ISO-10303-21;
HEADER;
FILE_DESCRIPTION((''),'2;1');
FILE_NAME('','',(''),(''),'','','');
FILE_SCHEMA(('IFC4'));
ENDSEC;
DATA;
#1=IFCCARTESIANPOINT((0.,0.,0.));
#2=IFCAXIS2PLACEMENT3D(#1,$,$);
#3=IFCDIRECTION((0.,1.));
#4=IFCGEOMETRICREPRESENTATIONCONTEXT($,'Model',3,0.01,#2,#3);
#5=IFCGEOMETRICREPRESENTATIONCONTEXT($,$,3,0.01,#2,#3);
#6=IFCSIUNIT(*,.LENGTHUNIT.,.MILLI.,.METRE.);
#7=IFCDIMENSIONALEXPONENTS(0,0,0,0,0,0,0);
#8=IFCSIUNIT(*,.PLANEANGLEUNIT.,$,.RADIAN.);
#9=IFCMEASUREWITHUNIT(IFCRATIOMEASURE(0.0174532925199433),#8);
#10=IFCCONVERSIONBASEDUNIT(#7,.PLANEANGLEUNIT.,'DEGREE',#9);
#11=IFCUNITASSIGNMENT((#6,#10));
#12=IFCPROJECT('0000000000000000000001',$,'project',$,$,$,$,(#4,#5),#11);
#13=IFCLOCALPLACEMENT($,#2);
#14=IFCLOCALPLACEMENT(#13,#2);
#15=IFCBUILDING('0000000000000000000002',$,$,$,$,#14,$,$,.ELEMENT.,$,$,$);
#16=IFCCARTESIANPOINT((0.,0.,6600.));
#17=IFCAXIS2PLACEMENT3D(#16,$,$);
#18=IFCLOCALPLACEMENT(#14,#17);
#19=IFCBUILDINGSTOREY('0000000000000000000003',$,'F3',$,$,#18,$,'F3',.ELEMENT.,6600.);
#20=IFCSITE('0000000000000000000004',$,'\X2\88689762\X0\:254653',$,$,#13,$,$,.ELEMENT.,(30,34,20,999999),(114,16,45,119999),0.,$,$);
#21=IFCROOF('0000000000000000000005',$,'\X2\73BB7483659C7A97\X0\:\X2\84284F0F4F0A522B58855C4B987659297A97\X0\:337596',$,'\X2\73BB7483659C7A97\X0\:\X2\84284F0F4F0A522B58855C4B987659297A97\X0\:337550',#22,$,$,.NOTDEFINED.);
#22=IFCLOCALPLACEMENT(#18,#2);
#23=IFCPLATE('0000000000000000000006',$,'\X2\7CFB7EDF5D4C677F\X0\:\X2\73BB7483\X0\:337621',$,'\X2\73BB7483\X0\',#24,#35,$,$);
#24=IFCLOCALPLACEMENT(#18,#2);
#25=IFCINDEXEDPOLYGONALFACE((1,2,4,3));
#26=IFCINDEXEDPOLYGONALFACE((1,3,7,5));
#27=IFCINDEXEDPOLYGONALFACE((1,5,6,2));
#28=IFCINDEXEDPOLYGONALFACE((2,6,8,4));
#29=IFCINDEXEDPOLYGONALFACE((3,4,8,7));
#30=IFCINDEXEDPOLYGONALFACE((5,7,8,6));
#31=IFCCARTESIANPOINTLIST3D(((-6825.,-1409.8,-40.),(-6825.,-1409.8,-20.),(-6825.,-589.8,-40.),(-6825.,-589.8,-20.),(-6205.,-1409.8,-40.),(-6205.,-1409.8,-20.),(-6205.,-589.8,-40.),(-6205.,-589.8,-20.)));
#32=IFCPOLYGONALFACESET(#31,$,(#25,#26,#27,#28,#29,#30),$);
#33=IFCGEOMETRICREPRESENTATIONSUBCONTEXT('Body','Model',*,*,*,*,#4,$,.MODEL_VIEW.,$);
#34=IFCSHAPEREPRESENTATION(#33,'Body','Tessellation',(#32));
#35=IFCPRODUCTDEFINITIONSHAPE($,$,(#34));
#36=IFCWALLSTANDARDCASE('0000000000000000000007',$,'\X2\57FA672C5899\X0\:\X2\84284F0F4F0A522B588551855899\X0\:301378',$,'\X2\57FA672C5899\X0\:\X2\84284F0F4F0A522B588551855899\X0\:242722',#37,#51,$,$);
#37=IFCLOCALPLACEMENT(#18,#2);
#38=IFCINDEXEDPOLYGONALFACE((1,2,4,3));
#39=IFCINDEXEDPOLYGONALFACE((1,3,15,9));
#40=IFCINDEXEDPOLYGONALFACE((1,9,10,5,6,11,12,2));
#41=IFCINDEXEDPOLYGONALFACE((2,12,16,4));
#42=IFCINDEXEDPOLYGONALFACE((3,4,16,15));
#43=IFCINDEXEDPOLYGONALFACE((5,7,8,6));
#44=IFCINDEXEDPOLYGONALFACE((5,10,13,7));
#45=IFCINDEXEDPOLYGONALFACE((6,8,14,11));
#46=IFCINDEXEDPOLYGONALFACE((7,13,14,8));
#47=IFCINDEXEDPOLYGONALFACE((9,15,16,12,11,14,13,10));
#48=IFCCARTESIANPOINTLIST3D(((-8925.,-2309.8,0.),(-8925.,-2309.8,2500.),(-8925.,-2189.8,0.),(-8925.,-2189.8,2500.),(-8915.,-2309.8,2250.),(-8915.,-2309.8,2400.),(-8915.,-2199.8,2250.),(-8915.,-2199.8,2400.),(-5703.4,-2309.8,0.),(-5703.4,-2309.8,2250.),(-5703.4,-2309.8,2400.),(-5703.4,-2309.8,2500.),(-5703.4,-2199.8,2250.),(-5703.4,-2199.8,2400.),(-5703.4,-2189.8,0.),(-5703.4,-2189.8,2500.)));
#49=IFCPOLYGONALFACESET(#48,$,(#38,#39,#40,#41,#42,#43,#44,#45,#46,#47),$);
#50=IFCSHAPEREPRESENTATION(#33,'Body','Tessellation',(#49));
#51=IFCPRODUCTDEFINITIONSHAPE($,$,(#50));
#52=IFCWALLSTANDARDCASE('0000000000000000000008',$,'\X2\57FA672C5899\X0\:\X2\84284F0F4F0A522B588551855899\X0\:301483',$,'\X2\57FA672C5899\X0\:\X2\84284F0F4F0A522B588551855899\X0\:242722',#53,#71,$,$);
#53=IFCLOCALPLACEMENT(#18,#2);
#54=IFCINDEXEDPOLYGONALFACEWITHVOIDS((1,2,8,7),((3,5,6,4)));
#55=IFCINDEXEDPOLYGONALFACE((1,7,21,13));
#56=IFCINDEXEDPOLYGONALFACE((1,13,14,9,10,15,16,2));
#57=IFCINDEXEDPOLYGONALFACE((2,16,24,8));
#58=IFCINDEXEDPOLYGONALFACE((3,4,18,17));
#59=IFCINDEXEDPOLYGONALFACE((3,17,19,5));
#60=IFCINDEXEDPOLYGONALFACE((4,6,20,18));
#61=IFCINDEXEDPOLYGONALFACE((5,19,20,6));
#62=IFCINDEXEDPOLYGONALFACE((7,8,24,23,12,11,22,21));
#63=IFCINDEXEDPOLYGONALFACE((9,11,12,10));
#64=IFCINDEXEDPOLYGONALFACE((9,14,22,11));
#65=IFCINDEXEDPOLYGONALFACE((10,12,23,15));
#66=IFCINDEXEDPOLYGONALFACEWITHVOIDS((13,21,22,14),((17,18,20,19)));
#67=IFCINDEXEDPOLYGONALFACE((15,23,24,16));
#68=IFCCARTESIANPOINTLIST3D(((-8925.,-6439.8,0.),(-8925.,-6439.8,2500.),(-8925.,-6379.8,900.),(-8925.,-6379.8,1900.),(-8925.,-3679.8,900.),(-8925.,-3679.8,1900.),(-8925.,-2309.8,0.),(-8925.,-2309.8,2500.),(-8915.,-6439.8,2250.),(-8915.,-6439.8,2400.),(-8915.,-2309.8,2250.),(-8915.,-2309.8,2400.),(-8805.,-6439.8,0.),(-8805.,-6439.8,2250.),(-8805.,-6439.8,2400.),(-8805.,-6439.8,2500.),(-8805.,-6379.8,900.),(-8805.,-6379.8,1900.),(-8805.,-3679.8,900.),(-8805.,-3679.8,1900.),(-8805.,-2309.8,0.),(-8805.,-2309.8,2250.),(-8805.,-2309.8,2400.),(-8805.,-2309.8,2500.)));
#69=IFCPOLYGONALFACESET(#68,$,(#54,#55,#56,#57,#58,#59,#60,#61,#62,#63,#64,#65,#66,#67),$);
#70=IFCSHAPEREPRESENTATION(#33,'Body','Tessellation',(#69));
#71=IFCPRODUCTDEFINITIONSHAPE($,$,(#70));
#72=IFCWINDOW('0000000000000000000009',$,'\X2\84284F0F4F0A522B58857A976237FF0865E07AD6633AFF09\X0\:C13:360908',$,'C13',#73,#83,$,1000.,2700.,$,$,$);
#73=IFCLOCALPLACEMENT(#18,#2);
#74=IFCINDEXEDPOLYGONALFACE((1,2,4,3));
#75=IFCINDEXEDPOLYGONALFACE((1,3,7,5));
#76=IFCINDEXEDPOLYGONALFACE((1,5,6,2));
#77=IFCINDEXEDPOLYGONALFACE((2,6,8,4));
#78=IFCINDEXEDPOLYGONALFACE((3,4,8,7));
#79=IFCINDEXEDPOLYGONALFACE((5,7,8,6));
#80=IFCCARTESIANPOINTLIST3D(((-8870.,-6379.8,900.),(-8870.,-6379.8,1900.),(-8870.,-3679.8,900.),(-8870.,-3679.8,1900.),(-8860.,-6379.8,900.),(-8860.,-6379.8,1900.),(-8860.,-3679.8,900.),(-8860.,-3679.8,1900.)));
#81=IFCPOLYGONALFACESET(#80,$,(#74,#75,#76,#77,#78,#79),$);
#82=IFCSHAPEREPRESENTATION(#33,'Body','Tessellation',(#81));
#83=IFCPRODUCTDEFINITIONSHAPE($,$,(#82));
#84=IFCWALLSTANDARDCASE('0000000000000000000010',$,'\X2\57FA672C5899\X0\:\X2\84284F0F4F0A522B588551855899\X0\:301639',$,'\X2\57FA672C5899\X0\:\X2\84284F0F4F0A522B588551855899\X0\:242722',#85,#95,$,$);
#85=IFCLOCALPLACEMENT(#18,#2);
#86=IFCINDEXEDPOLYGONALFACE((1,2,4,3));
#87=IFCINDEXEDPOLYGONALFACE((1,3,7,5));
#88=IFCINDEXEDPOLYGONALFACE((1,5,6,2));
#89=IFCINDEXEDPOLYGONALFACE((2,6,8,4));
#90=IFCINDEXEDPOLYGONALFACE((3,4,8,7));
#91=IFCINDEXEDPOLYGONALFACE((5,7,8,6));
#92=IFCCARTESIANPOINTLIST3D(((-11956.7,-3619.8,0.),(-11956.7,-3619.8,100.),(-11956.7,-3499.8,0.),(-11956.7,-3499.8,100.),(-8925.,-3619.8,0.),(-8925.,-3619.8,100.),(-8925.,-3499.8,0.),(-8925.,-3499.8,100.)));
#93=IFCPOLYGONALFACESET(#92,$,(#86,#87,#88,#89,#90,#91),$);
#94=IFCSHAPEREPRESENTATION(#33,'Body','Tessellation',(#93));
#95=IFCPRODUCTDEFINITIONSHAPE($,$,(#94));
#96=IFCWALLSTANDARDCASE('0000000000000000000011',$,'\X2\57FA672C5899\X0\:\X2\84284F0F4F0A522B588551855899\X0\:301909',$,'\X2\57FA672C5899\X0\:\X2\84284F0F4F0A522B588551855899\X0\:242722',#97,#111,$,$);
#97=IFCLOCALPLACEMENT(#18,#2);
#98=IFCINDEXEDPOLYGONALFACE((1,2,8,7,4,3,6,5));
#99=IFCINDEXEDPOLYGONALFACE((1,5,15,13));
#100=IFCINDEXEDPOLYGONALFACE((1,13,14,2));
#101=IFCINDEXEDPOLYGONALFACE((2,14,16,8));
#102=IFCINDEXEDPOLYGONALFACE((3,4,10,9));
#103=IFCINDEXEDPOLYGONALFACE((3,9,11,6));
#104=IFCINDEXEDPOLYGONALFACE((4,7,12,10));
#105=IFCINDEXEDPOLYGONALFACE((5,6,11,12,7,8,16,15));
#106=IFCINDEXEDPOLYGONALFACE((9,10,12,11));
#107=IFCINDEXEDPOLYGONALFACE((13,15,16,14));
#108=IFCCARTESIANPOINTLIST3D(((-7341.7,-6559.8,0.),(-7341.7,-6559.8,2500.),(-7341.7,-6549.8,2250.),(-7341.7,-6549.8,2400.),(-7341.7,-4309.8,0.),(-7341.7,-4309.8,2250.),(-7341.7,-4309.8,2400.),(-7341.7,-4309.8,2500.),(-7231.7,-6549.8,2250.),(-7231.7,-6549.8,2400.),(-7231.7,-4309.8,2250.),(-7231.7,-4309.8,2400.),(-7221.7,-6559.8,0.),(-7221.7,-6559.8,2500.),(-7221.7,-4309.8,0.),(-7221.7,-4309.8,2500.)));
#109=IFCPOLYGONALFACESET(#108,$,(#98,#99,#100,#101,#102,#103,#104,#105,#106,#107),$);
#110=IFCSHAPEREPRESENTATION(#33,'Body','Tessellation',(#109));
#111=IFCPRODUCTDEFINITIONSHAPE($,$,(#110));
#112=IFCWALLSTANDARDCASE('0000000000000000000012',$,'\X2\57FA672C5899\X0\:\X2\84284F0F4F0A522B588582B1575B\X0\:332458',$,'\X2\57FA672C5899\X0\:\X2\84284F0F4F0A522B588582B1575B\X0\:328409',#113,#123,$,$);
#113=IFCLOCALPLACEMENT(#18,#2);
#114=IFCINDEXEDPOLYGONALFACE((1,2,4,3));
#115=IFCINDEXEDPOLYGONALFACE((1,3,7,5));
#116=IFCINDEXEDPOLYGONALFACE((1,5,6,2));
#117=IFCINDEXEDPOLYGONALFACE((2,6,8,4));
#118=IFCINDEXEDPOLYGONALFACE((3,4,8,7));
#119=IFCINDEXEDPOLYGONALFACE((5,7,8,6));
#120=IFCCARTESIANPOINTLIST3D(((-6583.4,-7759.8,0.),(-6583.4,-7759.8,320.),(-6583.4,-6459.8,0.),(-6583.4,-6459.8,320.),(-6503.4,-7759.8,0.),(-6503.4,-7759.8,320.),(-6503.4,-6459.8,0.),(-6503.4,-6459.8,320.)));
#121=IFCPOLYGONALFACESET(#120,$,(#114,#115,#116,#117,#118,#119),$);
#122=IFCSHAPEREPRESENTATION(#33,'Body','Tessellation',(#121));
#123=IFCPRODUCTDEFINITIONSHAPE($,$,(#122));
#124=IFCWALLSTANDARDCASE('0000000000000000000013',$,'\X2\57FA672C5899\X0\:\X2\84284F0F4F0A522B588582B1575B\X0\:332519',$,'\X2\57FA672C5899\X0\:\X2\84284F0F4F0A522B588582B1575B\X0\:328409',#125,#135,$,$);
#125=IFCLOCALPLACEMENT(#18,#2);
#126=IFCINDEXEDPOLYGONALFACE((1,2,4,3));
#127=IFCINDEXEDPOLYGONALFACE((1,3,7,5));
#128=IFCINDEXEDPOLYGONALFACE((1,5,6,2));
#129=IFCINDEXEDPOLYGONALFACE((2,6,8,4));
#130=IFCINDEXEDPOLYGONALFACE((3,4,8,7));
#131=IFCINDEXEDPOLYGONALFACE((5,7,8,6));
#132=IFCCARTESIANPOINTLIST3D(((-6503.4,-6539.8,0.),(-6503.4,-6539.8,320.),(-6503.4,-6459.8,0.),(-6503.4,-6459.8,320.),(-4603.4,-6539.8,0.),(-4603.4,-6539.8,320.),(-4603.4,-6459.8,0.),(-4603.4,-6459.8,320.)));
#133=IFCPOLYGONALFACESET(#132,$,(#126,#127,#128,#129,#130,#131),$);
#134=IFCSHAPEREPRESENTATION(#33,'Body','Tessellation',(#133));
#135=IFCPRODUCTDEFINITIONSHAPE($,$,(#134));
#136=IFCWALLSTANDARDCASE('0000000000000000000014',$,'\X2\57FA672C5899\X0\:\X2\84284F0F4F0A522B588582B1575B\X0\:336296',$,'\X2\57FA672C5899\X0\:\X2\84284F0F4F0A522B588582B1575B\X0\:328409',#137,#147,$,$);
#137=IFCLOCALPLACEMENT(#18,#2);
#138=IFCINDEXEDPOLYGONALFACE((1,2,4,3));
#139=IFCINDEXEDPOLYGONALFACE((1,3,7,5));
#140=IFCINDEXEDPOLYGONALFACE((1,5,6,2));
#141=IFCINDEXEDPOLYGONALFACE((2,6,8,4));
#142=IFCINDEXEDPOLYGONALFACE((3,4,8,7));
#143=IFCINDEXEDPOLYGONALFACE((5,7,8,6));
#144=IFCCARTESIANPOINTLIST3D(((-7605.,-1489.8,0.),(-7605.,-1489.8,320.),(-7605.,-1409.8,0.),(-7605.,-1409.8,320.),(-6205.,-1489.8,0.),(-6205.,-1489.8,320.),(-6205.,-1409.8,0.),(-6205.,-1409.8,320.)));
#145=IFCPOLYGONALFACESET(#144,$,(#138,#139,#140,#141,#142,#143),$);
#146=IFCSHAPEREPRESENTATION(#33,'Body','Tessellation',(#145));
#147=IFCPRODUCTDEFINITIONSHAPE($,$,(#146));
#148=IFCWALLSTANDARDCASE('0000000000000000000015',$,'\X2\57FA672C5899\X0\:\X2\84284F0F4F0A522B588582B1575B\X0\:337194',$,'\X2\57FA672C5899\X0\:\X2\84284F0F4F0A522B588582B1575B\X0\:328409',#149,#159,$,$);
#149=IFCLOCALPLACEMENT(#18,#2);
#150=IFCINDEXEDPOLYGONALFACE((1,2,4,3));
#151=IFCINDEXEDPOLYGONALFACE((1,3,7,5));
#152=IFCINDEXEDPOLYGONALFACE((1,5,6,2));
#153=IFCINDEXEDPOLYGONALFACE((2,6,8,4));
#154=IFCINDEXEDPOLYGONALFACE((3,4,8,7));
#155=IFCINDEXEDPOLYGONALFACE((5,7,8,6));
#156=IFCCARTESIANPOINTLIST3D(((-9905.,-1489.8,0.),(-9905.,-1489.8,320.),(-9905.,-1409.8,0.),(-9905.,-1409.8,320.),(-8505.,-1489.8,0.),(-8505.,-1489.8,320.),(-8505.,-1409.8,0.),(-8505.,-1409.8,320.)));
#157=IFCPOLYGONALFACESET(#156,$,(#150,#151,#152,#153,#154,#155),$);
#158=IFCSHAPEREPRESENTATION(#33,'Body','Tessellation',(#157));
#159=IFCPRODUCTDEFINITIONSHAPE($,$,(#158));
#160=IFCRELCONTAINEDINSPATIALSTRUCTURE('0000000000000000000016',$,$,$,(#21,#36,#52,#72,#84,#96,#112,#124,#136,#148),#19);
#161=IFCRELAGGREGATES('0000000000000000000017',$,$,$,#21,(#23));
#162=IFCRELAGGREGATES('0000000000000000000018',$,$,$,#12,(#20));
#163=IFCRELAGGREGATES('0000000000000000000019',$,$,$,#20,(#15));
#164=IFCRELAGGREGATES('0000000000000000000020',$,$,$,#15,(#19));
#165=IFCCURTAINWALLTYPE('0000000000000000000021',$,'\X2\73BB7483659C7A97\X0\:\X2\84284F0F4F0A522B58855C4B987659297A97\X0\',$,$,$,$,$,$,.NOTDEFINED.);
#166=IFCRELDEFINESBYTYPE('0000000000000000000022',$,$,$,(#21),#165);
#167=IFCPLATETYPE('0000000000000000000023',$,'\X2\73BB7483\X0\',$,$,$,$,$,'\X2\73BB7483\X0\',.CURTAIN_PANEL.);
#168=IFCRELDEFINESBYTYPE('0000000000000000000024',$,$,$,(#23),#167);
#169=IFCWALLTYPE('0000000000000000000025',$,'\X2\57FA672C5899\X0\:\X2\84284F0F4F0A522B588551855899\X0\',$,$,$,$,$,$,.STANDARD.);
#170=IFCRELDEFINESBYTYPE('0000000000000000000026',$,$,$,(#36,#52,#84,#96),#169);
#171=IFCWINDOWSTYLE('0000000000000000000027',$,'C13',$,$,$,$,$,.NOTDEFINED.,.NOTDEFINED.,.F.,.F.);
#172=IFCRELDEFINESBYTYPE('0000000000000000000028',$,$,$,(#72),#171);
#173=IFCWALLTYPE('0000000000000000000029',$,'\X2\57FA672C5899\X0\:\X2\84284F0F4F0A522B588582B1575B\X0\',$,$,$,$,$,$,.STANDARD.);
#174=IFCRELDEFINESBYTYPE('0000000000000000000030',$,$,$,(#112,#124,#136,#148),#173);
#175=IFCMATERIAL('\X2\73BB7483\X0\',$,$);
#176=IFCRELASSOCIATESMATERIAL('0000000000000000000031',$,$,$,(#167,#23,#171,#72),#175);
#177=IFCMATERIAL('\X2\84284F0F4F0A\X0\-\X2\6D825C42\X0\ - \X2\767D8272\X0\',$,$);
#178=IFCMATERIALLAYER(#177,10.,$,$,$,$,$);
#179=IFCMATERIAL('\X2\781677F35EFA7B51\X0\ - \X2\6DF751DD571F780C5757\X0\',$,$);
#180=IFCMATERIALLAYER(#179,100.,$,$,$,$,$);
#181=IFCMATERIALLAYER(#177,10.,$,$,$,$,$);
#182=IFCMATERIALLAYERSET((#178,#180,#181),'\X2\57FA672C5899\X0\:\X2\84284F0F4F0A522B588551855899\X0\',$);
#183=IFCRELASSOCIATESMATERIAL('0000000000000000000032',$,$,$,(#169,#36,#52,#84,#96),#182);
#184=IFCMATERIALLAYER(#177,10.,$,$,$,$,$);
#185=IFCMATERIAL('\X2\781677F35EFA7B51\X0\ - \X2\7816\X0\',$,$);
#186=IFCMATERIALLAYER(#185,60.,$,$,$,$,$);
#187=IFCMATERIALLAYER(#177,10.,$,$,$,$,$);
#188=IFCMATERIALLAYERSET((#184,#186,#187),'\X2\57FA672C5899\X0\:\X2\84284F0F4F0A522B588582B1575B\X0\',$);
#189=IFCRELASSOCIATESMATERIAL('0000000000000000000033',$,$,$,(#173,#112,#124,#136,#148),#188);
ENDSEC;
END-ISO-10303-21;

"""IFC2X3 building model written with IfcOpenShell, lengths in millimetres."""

from ifc_helpers import new_model, entity, si_unit, converted_unit, direction, frame, frame_2d, origin, origin_2d_with_axis, place, context, subcontext, project, spatial, polyline, rectangle, extrude, clip, bounded_halfspace, source, transform, mapped, material, layer, layer_set, layer_usage, type_object, type_shapes, element, fill, aggregate, save


model = new_model("IFC2X3")

# Units and contexts
model_context = context("Model", 3, precision=0.01, world=origin(), true_north=direction((0.0, 1.0)))
context_of_model = context(None, 3, precision=0.01, world=origin(), true_north=direction((0.0, 1.0)))
body_context = subcontext(model_context, "Body", "Model", "MODEL_VIEW")
ifc_project = project(units=[si_unit("LENGTHUNIT", "METRE", prefix="MILLI"), converted_unit("PLANEANGLEUNIT", "DEGREE", entity("IfcRatioMeasure", 0.0174532925199433), si_unit("PLANEANGLEUNIT", "RADIAN"), dimensions=[0, 0, 0, 0, 0, 0, 0])], contexts=[model_context, context_of_model])

# Site, building, storey
site_placement = place(None, origin())
site = spatial("IfcSite", under=ifc_project, at=site_placement, Name="表面:254653", CompositionType="ELEMENT", RefLatitude=(30, 34, 20, 999999), RefLongitude=(114, 16, 45, 119999), RefElevation=0.0)
building_placement = place(site_placement, origin())
building = spatial("IfcBuilding", under=site, at=building_placement, CompositionType="ELEMENT")
storey_placement = place(building_placement, frame((0.0, 0.0, 6600.0)))
storey = spatial("IfcBuildingStorey", under=building, at=storey_placement, Name="F3", LongName="F3", CompositionType="ELEMENT", Elevation=6600.0)

# Roof, plate
curtain_wall_type_1 = type_object("IfcCurtainWallType", Name="玻璃斜窗:萨伏伊别墅屋顶天窗", PredefinedType="NOTDEFINED")
roof_placement = place(storey_placement, frame((0.0, 0.0, -6600.0)))
roof = element("IfcRoof", 1, at=roof_placement, inside=storey, type_object=curtain_wall_type_1, Name="玻璃斜窗:萨伏伊别墅屋顶天窗:337596", ObjectType="玻璃斜窗:萨伏伊别墅屋顶天窗:337550", ShapeType="NOTDEFINED")
ifc_material_1 = material(Name="玻璃")
plate_type_1 = type_object("IfcPlateType", Name="玻璃", ElementType="玻璃", PredefinedType="CURTAIN_PANEL", material=ifc_material_1)
shared_shape_1 = source(origin(), body_context, "Body", "SweptSolid", [
    extrude(rectangle(XDim=20.0, YDim=620.0, at=frame_2d((0.0, 0.0), x_axis=(1.0, 0.0))), frame((0.0, 30.0, 0.0), z_axis=(0.0, 0.0, 1.0), x_axis=(0.0, 1.0, 0.0)), (0.0, 0.0, 1.0), 820.0),
])
type_shapes(plate_type_1, [shared_shape_1])
plate_1_placement = place(roof_placement, frame((-6515.0, -1409.8, 6600.0), z_axis=(0.0, 1.0, 0.0), x_axis=(1.0, 0.0, 0.0)))
plate_1 = element("IfcPlate", 2, at=plate_1_placement, type_object=plate_type_1, material=ifc_material_1, Name="系统嵌板:玻璃:337621", ObjectType="玻璃", context=body_context, shape_type="MappedRepresentation", body=[
    mapped(shared_shape_1, transform((0.0, 0.0, 0.0), scale=1.0)),
])
aggregate(roof, [plate_1])

# Shared definitions
ifc_material_2 = material(Name="萨伏伊-涂层 - 白色")

# Wall, opening
ifc_layer_1 = layer(ifc_material_2, 10.0)
ifc_material_3 = material(Name="砖石建筑 - 混凝土砌块")
ifc_layer_2 = layer(ifc_material_3, 100.0)
ifc_layer_3 = layer(ifc_material_2, 10.0)
ifc_layer_set_1 = layer_set([ifc_layer_1, ifc_layer_2, ifc_layer_3], Name="基本墙:萨伏伊别墅内墙")
ifc_layer_usage_1 = layer_usage(ifc_layer_set_1, "AXIS2", "NEGATIVE", 60.0)
wall_type_1 = type_object("IfcWallType", Name="基本墙:萨伏伊别墅内墙", PredefinedType="STANDARD", material=ifc_layer_set_1)
wall_1_placement = place(storey_placement, frame((-5703.4, -2249.8, 0.0), z_axis=(0.0, 0.0, 1.0), x_axis=(-1.0, 0.0, 0.0)))
wall_1 = element("IfcWallStandardCase", 3, at=wall_1_placement, inside=storey, type_object=wall_type_1, material=ifc_layer_usage_1, Name="基本墙:萨伏伊别墅内墙:301378", ObjectType="基本墙:萨伏伊别墅内墙:242722", context=body_context, shape_type="SweptSolid", body=[
    extrude(rectangle(XDim=3221.6, YDim=120.0, at=frame_2d((1610.8, 0.0), x_axis=(-1.0, 0.0))), origin(), (0.0, 0.0, 1.0), 2500.0),
])
opening_1_placement = place(storey_placement, frame((-5703.4, -2249.8, 0.0), z_axis=(0.0, 0.0, 1.0), x_axis=(-1.0, 0.0, 0.0)))
element("IfcOpeningElement", 4, at=opening_1_placement, cuts=wall_1, ObjectType="Opening", context=body_context, shape_type="SweptSolid", body=[
    extrude(rectangle(XDim=3211.6, YDim=110.0, at=frame_2d((-299.2, -11.0), x_axis=(1.0, 0.0))), frame((1905.0, 16.0, 2250.0)), (0.0, 0.0, 1.0), 150.0),
])

# Wall, opening, window
ifc_layer_usage_2 = layer_usage(ifc_layer_set_1, "AXIS2", "NEGATIVE", 60.0)
wall_2_placement = place(storey_placement, frame((-8865.0, -2309.8, 0.0), z_axis=(0.0, 0.0, 1.0), x_axis=(0.0, -1.0, 0.0)))
wall_2 = element("IfcWallStandardCase", 5, at=wall_2_placement, inside=storey, type_object=wall_type_1, material=ifc_layer_usage_2, Name="基本墙:萨伏伊别墅内墙:301483", ObjectType="基本墙:萨伏伊别墅内墙:242722", context=body_context, shape_type="Clipping", body=[
    clip(extrude(rectangle(XDim=4130.0, YDim=120.0, at=frame_2d((2065.0, 0.0), x_axis=(-1.0, 0.0))), origin(), (0.0, 0.0, 1.0), 2500.0), bounded_halfspace(frame((4130.0, -50.0, 2250.0), z_axis=(0.0, -1.0, 0.0), x_axis=(0.0, 0.0, 1.0)), True, frame((4130.0, -50.0, 2250.0), z_axis=(0.0, -1.0, 0.0), x_axis=(0.0, 0.0, 1.0)), polyline([(0.0, 0.0), (150.0, 0.0), (150.0, 4130.0), (0.0, 4130.0), (0.0, 0.0)]))),
])
opening_2_placement = place(wall_2_placement, frame((4070.0, 60.0, 900.0)))
opening_2 = element("IfcOpeningElement", 6, at=opening_2_placement, cuts=wall_2, ObjectType="Opening", context=body_context, shape_type="SweptSolid", body=[
    extrude(rectangle(XDim=1000.0, YDim=2700.0, at=frame_2d((500.0, 1350.0), x_axis=(1.0, 0.0))), frame((0.0, 0.0, 0.0), z_axis=(0.0, -1.0, 0.0), x_axis=(0.0, 0.0, 1.0)), (0.0, 0.0, 1.0), 120.0),
])
window_style = type_object("IfcWindowStyle", Name="C13", ConstructionType="NOTDEFINED", OperationType="NOTDEFINED", ParameterTakesPrecedence=False, Sizeable=False, material=ifc_material_1)
shared_shape_2 = source(origin(), body_context, "Body", "SweptSolid", [
    extrude(rectangle(XDim=10.0, YDim=2700.0, at=origin_2d_with_axis()), frame((1350.0, 60.0, 0.0), z_axis=(0.0, 0.0, 1.0), x_axis=(0.0, 1.0, 0.0)), (0.0, 0.0, 1.0), 1000.0),
])
type_shapes(window_style, [shared_shape_2])
window_placement = place(opening_2_placement, frame((0.0, 0.0, 0.0), z_axis=(0.0, 0.0, 1.0), x_axis=(-1.0, 0.0, 0.0)))
window = element("IfcWindow", 7, at=window_placement, inside=storey, type_object=window_style, material=ifc_material_1, Name="萨伏伊别墅窗户（无竖挺）:C13:360908", ObjectType="C13", OverallHeight=1000.0, OverallWidth=2700.0, context=body_context, shape_type="MappedRepresentation", body=[
    mapped(shared_shape_2, transform((0.0, 0.0, 0.0), scale=1.0)),
])
fill(opening_2, window)

# Wall
ifc_layer_usage_3 = layer_usage(ifc_layer_set_1, "AXIS2", "NEGATIVE", 60.0)
wall_3_placement = place(storey_placement, frame((-8925.0, -3559.8, 0.0), z_axis=(0.0, 0.0, 1.0), x_axis=(-1.0, 0.0, 0.0)))
element("IfcWallStandardCase", 8, at=wall_3_placement, inside=storey, type_object=wall_type_1, material=ifc_layer_usage_3, Name="基本墙:萨伏伊别墅内墙:301639", ObjectType="基本墙:萨伏伊别墅内墙:242722", context=body_context, shape_type="SweptSolid", body=[
    extrude(rectangle(XDim=3031.7, YDim=120.0, at=frame_2d((1515.8, 0.0), x_axis=(-1.0, 0.0))), origin(), (0.0, 0.0, 1.0), 100.0),
])

# Wall, opening
ifc_layer_usage_4 = layer_usage(ifc_layer_set_1, "AXIS2", "NEGATIVE", 60.0)
wall_4_placement = place(storey_placement, frame((-7281.7, -4309.8, 0.0), z_axis=(0.0, 0.0, 1.0), x_axis=(0.0, -1.0, 0.0)))
wall_4 = element("IfcWallStandardCase", 9, at=wall_4_placement, inside=storey, type_object=wall_type_1, material=ifc_layer_usage_4, Name="基本墙:萨伏伊别墅内墙:301909", ObjectType="基本墙:萨伏伊别墅内墙:242722", context=body_context, shape_type="SweptSolid", body=[
    extrude(rectangle(XDim=2250.0, YDim=120.0, at=frame_2d((1125.0, 0.0), x_axis=(-1.0, 0.0))), origin(), (0.0, 0.0, 1.0), 2500.0),
])
opening_3_placement = place(storey_placement, frame((-7281.7, -4309.8, 0.0), z_axis=(0.0, 0.0, 1.0), x_axis=(0.0, -1.0, 0.0)))
element("IfcOpeningElement", 10, at=opening_3_placement, cuts=wall_4, ObjectType="Opening", context=body_context, shape_type="SweptSolid", body=[
    extrude(rectangle(XDim=110.0, YDim=2240.0, at=frame_2d((11.0, 202.0), x_axis=(1.0, 0.0))), frame((1322.0, -16.0, 2250.0), z_axis=(0.0, 0.0, 1.0), x_axis=(0.0, 1.0, 0.0)), (0.0, 0.0, 1.0), 150.0),
])

# Walls
ifc_layer_4 = layer(ifc_material_2, 10.0)
ifc_material_4 = material(Name="砖石建筑 - 砖")
ifc_layer_5 = layer(ifc_material_4, 60.0)
ifc_layer_6 = layer(ifc_material_2, 10.0)
ifc_layer_set_2 = layer_set([ifc_layer_4, ifc_layer_5, ifc_layer_6], Name="基本墙:萨伏伊别墅花坛")
ifc_layer_usage_5 = layer_usage(ifc_layer_set_2, "AXIS2", "NEGATIVE", 40.0)
wall_type_2 = type_object("IfcWallType", Name="基本墙:萨伏伊别墅花坛", PredefinedType="STANDARD", material=ifc_layer_set_2)
wall_5_placement = place(storey_placement, frame((-6543.4, -7759.8, 0.0), z_axis=(0.0, 0.0, 1.0), x_axis=(0.0, 1.0, 0.0)))
element("IfcWallStandardCase", 11, at=wall_5_placement, inside=storey, type_object=wall_type_2, material=ifc_layer_usage_5, Name="基本墙:萨伏伊别墅花坛:332458", ObjectType="基本墙:萨伏伊别墅花坛:328409", context=body_context, shape_type="SweptSolid", body=[
    extrude(rectangle(XDim=1300.0, YDim=80.0, at=frame_2d((650.0, 0.0), x_axis=(-1.0, 0.0))), origin(), (0.0, 0.0, 1.0), 320.0),
])
ifc_layer_usage_6 = layer_usage(ifc_layer_set_2, "AXIS2", "NEGATIVE", 40.0)
wall_6_placement = place(storey_placement, frame((-6503.4, -6499.8, 0.0)))
element("IfcWallStandardCase", 12, at=wall_6_placement, inside=storey, type_object=wall_type_2, material=ifc_layer_usage_6, Name="基本墙:萨伏伊别墅花坛:332519", ObjectType="基本墙:萨伏伊别墅花坛:328409", context=body_context, shape_type="SweptSolid", body=[
    extrude(rectangle(XDim=1900.0, YDim=80.0, at=frame_2d((950.0, 0.0), x_axis=(-1.0, 0.0))), origin(), (0.0, 0.0, 1.0), 320.0),
])
ifc_layer_usage_7 = layer_usage(ifc_layer_set_2, "AXIS2", "NEGATIVE", 40.0)
wall_7_placement = place(storey_placement, frame((-6205.0, -1449.8, 0.0), z_axis=(0.0, 0.0, 1.0), x_axis=(-1.0, 0.0, 0.0)))
element("IfcWallStandardCase", 13, at=wall_7_placement, inside=storey, type_object=wall_type_2, material=ifc_layer_usage_7, Name="基本墙:萨伏伊别墅花坛:336296", ObjectType="基本墙:萨伏伊别墅花坛:328409", context=body_context, shape_type="SweptSolid", body=[
    extrude(rectangle(XDim=1400.0, YDim=80.0, at=frame_2d((700.0, 0.0), x_axis=(-1.0, 0.0))), origin(), (0.0, 0.0, 1.0), 320.0),
])
ifc_layer_usage_8 = layer_usage(ifc_layer_set_2, "AXIS2", "NEGATIVE", 40.0)
wall_8_placement = place(storey_placement, frame((-8505.0, -1449.8, 0.0), z_axis=(0.0, 0.0, 1.0), x_axis=(-1.0, 0.0, 0.0)))
element("IfcWallStandardCase", 14, at=wall_8_placement, inside=storey, type_object=wall_type_2, material=ifc_layer_usage_8, Name="基本墙:萨伏伊别墅花坛:337194", ObjectType="基本墙:萨伏伊别墅花坛:328409", context=body_context, shape_type="SweptSolid", body=[
    extrude(rectangle(XDim=1400.0, YDim=80.0, at=frame_2d((700.0, 0.0), x_axis=(-1.0, 0.0))), origin(), (0.0, 0.0, 1.0), 320.0),
])

save(model, "model.ifc")
